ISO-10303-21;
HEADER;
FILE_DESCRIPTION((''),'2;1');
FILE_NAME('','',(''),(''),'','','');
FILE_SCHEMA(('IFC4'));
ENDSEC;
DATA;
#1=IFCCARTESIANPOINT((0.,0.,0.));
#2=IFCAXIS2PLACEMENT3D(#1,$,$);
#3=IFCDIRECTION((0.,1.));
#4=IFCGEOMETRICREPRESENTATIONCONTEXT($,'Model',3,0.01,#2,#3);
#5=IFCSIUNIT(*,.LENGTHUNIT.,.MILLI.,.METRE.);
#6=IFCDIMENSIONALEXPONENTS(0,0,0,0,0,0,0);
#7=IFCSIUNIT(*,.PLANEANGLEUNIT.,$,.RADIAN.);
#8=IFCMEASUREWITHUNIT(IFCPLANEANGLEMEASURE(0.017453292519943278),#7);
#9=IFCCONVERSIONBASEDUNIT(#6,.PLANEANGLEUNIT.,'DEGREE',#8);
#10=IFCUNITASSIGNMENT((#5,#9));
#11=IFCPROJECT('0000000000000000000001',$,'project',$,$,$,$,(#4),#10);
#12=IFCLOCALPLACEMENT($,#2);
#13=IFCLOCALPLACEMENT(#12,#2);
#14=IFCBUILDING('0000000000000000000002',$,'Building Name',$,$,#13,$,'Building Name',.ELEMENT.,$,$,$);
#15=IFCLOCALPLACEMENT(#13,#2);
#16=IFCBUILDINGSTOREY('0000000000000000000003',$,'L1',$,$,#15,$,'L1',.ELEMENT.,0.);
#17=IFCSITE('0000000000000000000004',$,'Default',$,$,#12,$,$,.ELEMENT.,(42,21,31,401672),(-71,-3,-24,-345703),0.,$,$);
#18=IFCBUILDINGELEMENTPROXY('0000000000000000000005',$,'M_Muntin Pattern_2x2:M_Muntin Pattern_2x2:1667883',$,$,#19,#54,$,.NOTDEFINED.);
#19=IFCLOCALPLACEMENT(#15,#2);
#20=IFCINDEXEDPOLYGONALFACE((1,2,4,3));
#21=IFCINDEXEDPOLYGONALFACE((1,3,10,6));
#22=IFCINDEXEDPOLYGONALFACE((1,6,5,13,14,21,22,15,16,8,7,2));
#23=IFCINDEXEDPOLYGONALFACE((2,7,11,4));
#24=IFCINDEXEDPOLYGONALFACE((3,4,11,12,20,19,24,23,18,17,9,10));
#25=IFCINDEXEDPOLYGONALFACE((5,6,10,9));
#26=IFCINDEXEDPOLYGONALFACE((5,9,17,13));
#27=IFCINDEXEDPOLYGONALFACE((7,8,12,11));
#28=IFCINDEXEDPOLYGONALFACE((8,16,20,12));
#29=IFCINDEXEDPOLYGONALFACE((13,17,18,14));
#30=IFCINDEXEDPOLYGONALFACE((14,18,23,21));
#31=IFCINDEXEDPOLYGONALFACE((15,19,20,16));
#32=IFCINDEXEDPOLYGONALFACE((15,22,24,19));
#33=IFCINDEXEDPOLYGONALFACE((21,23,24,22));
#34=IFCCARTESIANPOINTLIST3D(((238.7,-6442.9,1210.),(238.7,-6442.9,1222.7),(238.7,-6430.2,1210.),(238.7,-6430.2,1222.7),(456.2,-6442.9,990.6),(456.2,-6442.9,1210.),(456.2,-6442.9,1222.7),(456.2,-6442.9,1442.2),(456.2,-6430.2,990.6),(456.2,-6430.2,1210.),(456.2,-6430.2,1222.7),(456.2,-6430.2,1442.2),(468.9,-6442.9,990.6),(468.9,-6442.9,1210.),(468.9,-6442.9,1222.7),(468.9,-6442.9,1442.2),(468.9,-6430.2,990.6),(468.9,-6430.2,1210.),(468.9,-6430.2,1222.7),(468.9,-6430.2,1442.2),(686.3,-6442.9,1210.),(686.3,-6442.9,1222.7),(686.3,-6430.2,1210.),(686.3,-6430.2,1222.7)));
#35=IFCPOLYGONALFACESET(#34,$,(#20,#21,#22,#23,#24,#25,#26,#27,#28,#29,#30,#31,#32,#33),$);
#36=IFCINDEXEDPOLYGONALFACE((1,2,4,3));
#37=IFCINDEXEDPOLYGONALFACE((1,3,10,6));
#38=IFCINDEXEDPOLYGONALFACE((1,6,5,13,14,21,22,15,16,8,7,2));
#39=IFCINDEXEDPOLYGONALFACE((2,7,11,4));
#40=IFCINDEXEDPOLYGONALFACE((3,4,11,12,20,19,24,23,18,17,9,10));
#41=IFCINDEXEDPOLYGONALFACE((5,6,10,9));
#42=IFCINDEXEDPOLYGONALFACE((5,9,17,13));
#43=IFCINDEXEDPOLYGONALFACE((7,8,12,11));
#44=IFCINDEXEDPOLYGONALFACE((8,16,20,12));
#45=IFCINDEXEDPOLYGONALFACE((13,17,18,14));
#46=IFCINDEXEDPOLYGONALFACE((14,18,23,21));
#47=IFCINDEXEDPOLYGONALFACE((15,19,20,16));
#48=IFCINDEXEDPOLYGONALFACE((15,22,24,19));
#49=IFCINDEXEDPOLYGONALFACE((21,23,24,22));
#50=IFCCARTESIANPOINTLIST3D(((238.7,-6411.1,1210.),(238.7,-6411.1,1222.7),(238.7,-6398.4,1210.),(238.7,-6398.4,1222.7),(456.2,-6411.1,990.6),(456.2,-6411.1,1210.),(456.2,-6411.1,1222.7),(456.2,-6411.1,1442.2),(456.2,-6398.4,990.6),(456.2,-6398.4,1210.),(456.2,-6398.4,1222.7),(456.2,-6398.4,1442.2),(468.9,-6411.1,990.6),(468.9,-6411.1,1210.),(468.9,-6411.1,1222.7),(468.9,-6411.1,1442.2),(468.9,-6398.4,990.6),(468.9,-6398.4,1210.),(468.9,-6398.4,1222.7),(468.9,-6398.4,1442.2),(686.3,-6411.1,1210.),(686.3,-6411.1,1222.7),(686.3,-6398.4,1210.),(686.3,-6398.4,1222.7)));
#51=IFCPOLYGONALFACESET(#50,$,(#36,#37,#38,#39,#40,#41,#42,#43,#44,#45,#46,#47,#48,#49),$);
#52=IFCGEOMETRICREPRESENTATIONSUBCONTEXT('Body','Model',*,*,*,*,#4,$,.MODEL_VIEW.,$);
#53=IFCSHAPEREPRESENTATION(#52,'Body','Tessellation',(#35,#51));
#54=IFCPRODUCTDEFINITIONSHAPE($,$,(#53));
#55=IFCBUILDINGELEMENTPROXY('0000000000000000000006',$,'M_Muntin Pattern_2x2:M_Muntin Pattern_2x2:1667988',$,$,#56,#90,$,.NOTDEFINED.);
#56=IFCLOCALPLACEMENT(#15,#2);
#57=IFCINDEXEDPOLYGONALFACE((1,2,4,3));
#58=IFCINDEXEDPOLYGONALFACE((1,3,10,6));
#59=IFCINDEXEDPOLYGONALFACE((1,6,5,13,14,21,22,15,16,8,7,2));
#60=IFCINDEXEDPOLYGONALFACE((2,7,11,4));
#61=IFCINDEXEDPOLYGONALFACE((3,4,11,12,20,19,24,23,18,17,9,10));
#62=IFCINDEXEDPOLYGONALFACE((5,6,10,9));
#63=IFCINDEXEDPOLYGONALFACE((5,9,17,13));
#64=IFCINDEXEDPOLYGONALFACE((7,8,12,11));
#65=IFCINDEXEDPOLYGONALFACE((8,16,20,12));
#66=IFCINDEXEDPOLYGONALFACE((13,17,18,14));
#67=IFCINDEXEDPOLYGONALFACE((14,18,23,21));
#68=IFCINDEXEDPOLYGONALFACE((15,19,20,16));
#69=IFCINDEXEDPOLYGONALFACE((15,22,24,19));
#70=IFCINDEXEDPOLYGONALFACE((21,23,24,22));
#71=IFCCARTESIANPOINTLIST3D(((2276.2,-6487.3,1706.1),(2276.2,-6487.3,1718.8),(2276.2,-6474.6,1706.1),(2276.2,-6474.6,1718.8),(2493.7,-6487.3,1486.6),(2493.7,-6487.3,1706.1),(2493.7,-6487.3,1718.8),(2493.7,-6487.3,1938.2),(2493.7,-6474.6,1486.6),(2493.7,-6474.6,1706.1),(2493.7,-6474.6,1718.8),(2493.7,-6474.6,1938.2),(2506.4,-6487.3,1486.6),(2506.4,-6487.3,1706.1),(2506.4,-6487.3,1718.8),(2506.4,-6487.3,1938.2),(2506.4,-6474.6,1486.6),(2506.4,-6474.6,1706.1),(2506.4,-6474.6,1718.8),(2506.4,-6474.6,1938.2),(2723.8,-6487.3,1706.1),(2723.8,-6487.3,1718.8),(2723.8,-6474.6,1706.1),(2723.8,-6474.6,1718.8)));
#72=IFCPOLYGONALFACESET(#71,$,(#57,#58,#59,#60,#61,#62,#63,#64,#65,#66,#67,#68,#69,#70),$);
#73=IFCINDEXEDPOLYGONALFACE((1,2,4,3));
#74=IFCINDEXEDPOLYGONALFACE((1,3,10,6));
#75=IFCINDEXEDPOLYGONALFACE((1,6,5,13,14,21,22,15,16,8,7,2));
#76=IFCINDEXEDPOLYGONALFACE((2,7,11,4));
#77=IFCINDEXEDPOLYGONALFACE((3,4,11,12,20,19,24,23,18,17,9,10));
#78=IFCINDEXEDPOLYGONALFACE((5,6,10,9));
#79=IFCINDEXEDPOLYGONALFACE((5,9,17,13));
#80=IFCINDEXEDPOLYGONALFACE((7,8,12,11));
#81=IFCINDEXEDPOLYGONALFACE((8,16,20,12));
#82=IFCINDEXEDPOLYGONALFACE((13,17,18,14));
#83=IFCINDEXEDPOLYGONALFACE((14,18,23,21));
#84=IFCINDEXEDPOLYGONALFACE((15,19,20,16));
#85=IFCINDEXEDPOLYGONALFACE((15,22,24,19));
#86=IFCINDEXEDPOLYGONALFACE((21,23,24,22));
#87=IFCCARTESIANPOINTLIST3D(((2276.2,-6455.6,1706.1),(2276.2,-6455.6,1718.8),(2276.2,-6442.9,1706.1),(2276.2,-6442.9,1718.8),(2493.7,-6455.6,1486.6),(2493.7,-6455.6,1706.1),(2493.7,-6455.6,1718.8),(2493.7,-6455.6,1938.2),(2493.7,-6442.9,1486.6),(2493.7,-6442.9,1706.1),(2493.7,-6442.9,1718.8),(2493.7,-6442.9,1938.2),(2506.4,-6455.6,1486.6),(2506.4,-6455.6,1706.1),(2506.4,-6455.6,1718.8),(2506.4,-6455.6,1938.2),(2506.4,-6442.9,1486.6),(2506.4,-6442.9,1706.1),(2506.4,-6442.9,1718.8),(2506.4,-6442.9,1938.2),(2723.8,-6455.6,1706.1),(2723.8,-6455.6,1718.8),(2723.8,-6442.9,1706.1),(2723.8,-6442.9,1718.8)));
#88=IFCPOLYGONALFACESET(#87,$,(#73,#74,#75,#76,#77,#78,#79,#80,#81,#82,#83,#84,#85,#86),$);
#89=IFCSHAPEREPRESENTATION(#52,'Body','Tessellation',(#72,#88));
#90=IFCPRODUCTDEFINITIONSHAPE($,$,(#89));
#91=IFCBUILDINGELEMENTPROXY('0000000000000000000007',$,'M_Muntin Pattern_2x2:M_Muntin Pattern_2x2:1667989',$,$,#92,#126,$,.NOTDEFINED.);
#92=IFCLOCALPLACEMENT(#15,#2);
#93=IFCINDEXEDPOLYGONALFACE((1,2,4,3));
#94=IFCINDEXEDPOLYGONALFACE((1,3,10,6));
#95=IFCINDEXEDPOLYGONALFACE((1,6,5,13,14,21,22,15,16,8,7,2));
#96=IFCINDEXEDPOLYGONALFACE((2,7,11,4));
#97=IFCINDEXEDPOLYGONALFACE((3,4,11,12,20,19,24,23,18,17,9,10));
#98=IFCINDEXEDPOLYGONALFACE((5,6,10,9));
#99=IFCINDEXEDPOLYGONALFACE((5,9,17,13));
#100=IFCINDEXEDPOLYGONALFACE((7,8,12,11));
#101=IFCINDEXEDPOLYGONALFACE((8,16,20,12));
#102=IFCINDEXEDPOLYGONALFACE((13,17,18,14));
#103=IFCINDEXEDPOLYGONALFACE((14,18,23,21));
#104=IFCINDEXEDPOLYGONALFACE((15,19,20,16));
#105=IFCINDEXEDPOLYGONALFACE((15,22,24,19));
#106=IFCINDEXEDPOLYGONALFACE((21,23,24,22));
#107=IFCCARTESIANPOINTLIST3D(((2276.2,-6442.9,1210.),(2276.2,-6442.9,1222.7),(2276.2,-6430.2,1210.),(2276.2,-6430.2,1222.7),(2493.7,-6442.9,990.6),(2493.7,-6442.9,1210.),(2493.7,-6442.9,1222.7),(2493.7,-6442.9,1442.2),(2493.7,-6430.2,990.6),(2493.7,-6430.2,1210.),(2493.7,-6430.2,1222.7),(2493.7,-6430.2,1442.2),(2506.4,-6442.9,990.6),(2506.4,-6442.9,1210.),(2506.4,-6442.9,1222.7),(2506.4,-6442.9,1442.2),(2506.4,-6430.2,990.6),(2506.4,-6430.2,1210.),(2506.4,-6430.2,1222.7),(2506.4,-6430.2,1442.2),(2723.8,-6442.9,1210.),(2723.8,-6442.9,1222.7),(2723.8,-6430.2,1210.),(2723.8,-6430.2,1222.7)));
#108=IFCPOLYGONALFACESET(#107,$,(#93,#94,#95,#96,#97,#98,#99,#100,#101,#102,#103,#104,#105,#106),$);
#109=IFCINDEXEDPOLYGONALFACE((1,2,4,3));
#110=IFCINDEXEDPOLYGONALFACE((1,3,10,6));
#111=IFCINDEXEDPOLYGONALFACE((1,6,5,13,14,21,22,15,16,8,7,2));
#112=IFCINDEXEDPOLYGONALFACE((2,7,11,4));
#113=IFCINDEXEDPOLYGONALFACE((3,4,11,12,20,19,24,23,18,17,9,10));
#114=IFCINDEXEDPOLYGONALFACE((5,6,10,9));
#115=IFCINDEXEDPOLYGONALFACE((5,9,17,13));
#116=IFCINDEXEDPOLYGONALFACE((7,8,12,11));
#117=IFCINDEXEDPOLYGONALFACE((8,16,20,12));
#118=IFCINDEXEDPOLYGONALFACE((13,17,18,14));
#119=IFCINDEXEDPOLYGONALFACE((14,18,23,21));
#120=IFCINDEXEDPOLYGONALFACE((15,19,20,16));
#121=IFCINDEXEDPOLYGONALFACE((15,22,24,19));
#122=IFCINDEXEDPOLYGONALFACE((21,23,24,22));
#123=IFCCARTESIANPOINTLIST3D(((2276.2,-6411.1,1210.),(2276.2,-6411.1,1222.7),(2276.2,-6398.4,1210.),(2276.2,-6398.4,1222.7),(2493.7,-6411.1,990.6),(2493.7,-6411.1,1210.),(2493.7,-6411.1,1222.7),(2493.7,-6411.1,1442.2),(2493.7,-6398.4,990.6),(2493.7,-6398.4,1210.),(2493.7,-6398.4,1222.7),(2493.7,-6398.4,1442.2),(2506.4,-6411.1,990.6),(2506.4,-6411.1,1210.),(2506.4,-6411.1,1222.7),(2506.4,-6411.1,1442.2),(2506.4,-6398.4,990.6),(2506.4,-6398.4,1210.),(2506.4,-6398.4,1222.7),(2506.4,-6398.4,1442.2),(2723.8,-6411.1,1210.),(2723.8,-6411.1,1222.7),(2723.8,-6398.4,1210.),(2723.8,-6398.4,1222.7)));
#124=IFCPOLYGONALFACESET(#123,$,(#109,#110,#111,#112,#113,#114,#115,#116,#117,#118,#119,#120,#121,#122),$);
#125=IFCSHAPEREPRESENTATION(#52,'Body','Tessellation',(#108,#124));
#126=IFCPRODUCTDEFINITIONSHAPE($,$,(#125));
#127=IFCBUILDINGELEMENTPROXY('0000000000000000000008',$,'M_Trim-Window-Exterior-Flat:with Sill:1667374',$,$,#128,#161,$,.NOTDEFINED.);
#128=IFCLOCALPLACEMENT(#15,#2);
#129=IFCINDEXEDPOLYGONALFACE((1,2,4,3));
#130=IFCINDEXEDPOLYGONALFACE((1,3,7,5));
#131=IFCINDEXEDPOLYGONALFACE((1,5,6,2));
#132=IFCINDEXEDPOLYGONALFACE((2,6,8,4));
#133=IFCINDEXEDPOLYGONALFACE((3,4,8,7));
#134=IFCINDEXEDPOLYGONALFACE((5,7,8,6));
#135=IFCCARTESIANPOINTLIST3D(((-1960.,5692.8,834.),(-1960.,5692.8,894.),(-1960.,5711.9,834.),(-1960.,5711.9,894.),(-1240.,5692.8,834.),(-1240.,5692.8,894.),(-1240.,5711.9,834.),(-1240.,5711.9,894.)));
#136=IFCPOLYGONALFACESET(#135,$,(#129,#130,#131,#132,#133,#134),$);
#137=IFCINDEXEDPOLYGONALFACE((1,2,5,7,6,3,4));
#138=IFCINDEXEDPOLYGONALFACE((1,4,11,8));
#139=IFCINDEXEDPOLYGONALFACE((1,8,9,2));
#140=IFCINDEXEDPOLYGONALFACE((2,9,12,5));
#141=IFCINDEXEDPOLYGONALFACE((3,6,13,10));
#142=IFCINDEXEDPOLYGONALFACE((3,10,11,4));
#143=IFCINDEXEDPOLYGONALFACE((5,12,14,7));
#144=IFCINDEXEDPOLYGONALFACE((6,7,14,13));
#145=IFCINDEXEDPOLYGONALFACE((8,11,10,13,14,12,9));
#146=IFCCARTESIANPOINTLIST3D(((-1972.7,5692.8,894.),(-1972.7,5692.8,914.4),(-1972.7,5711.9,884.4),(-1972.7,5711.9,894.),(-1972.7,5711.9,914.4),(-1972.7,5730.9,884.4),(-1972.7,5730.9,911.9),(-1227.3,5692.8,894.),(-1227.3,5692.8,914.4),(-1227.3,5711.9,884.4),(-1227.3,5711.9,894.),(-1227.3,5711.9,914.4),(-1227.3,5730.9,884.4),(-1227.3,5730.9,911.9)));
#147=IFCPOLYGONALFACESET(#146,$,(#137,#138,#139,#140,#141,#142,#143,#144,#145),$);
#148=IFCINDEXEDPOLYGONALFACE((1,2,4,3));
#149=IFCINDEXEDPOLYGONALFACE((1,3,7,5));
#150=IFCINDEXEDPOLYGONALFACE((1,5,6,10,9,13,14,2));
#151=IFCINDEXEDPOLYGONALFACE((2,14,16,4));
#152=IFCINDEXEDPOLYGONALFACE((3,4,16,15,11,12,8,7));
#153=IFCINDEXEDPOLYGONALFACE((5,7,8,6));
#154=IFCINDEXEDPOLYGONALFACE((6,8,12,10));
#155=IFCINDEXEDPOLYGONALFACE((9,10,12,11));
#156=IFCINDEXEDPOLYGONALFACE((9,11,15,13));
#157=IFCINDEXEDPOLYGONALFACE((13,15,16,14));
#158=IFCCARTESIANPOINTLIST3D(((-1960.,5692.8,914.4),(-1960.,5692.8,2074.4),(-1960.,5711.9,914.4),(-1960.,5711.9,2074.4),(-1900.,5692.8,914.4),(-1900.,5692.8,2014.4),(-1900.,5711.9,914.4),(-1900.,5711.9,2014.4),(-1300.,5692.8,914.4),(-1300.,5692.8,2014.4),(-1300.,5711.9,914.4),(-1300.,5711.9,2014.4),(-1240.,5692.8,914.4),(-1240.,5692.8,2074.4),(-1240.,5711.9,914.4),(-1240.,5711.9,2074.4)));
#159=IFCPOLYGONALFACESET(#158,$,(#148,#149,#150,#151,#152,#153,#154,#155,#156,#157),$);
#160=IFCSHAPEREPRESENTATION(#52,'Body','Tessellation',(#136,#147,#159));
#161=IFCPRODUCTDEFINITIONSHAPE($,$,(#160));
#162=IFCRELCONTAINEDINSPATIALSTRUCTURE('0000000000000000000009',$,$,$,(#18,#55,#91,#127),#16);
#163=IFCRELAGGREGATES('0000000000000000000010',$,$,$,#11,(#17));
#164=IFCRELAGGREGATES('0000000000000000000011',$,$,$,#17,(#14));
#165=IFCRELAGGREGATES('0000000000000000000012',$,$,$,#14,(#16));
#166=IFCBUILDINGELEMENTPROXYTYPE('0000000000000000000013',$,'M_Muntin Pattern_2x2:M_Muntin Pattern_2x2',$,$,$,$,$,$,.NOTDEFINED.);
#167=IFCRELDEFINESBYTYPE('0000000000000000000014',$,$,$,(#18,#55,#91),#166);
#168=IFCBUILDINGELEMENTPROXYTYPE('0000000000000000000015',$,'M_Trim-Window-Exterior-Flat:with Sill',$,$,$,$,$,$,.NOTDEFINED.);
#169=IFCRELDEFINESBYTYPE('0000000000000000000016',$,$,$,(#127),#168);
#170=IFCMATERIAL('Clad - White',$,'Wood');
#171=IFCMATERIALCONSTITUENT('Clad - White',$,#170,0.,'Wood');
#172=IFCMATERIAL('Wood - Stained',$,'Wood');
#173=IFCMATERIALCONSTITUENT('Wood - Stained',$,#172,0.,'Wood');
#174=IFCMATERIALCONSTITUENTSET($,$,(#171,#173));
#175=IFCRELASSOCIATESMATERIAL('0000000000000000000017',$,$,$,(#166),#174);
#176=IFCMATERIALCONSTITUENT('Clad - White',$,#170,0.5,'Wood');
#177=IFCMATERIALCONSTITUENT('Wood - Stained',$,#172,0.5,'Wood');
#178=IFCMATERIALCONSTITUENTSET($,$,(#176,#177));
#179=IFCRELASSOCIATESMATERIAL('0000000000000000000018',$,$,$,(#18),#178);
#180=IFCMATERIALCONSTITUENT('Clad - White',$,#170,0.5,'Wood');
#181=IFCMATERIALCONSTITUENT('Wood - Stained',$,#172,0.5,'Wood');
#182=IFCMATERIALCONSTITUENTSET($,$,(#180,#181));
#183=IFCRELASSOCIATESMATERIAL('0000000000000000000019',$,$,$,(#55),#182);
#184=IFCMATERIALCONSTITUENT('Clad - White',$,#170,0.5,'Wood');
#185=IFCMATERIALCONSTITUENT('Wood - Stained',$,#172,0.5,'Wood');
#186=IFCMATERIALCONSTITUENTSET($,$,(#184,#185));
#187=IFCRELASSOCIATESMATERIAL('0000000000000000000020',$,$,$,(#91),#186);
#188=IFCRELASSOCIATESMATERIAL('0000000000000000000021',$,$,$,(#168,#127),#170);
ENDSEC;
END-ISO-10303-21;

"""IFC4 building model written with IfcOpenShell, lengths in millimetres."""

from ifc_helpers import new_model, entity, si_unit, converted_unit, direction, frame, origin, place, context, subcontext, project, spatial, indexed_curve, outline, extrude, source, transform, mapped, material, constituent, constituent_set, type_object, type_shapes, element, save


model = new_model("IFC4")

# Units and contexts
model_context = context("Model", 3, precision=0.01, world=origin(), true_north=direction((0.0, 1.0)))
body_context = subcontext(model_context, "Body", "Model", "MODEL_VIEW")
ifc_project = project(units=[si_unit("LENGTHUNIT", "METRE", prefix="MILLI"), converted_unit("PLANEANGLEUNIT", "DEGREE", entity("IfcPlaneAngleMeasure", 0.017453292519943278), si_unit("PLANEANGLEUNIT", "RADIAN"), dimensions=[0, 0, 0, 0, 0, 0, 0])], contexts=[model_context])

# Site, building, storey
site_placement = place(None, origin())
site = spatial("IfcSite", under=ifc_project, at=site_placement, Name="Default", CompositionType="ELEMENT", RefLatitude=(42, 21, 31, 401672), RefLongitude=(-71, -3, -24, -345703), RefElevation=0.0)
building_placement = place(site_placement, origin())
building = spatial("IfcBuilding", under=site, at=building_placement, Name="Building Name", LongName="Building Name", CompositionType="ELEMENT")
storey_placement = place(building_placement, origin())
storey = spatial("IfcBuildingStorey", under=building, at=storey_placement, Name="L1", LongName="L1", CompositionType="ELEMENT", Elevation=0.0)

# Building element proxies
ifc_material_1 = material(Name="Clad - White", Category="Wood")
ifc_material_2 = material(Name="Wood - Stained", Category="Wood")
ifc_constituent_1 = constituent(ifc_material_1, Name="Clad - White", Category="Wood", fraction=0.0)
ifc_constituent_2 = constituent(ifc_material_2, Name="Wood - Stained", Category="Wood", fraction=0.0)
ifc_constituent_set_1 = constituent_set(constituents=[ifc_constituent_1, ifc_constituent_2])
building_element_proxy_type_1 = type_object("IfcBuildingElementProxyType", Name="M_Muntin Pattern_2x2:M_Muntin Pattern_2x2", PredefinedType="NOTDEFINED", material=ifc_constituent_set_1)
shared_shape_1 = source(origin(), body_context, "Body", "SweptSolid", [
    extrude(outline(indexed_curve([(6.4, -6.4), (225.8, -6.4), (225.8, 6.3), (6.4, 6.3), (6.4, 223.8), (-6.3, 223.8), (-6.3, 6.3), (-225.8, 6.3), (-225.8, -6.4), (-6.3, -6.4), (-6.3, -223.8), (6.4, -223.8), (6.4, -6.4)], self_intersect=False)), frame((0.0, 9.5, 225.8), z_axis=(0.0, 1.0, 0.0), x_axis=(0.0, 0.0, 1.0)), (0.0, 0.0, 1.0), 12.7),
    extrude(outline(indexed_curve([(6.4, -6.4), (225.8, -6.4), (225.8, 6.3), (6.4, 6.3), (6.4, 223.8), (-6.3, 223.8), (-6.3, 6.3), (-225.8, 6.3), (-225.8, -6.4), (-6.3, -6.4), (-6.3, -223.8), (6.4, -223.8), (6.4, -6.4)], self_intersect=False)), frame((0.0, -22.2, 225.8), z_axis=(0.0, 1.0, 0.0), x_axis=(0.0, 0.0, 1.0)), (0.0, 0.0, 1.0), 12.7),
])
type_shapes(building_element_proxy_type_1, [shared_shape_1])
ifc_constituent_3 = constituent(ifc_material_1, Name="Clad - White", Category="Wood", fraction=0.5)
ifc_constituent_4 = constituent(ifc_material_2, Name="Wood - Stained", Category="Wood", fraction=0.5)
ifc_constituent_set_2 = constituent_set(constituents=[ifc_constituent_3, ifc_constituent_4])
proxy_1_placement = place(storey_placement, frame((462.5, -6420.6, 990.6), z_axis=(0.0, 0.0, 1.0), x_axis=(-1.0, 0.0, 0.0)))
element("IfcBuildingElementProxy", 1, at=proxy_1_placement, inside=storey, type_object=building_element_proxy_type_1, material=ifc_constituent_set_2, Name="M_Muntin Pattern_2x2:M_Muntin Pattern_2x2:1667883", PredefinedType="NOTDEFINED", context=body_context, shape_type="MappedRepresentation", body=[
    mapped(shared_shape_1, transform((0.0, 0.0, 0.0), scale=1.0)),
])
ifc_constituent_5 = constituent(ifc_material_1, Name="Clad - White", Category="Wood", fraction=0.5)
ifc_constituent_6 = constituent(ifc_material_2, Name="Wood - Stained", Category="Wood", fraction=0.5)
ifc_constituent_set_3 = constituent_set(constituents=[ifc_constituent_5, ifc_constituent_6])
proxy_2_placement = place(storey_placement, frame((2500.0, -6465.1, 1486.6), z_axis=(0.0, 0.0, 1.0), x_axis=(-1.0, 0.0, 0.0)))
element("IfcBuildingElementProxy", 2, at=proxy_2_placement, inside=storey, type_object=building_element_proxy_type_1, material=ifc_constituent_set_3, Name="M_Muntin Pattern_2x2:M_Muntin Pattern_2x2:1667988", PredefinedType="NOTDEFINED", context=body_context, shape_type="MappedRepresentation", body=[
    mapped(shared_shape_1, transform((0.0, 0.0, 0.0), scale=1.0)),
])
ifc_constituent_7 = constituent(ifc_material_1, Name="Clad - White", Category="Wood", fraction=0.5)
ifc_constituent_8 = constituent(ifc_material_2, Name="Wood - Stained", Category="Wood", fraction=0.5)
ifc_constituent_set_4 = constituent_set(constituents=[ifc_constituent_7, ifc_constituent_8])
proxy_3_placement = place(storey_placement, frame((2500.0, -6420.6, 990.6), z_axis=(0.0, 0.0, 1.0), x_axis=(-1.0, 0.0, 0.0)))
element("IfcBuildingElementProxy", 3, at=proxy_3_placement, inside=storey, type_object=building_element_proxy_type_1, material=ifc_constituent_set_4, Name="M_Muntin Pattern_2x2:M_Muntin Pattern_2x2:1667989", PredefinedType="NOTDEFINED", context=body_context, shape_type="MappedRepresentation", body=[
    mapped(shared_shape_1, transform((0.0, 0.0, 0.0), scale=1.0)),
])
building_element_proxy_type_2 = type_object("IfcBuildingElementProxyType", Name="M_Trim-Window-Exterior-Flat:with Sill", PredefinedType="NOTDEFINED", material=ifc_material_1)
shared_shape_2 = source(origin(), body_context, "Body", "SweptSolid", [
    extrude(outline(indexed_curve([(-360.0, -30.0), (360.0, -30.0), (360.0, 30.0), (-360.0, 30.0), (-360.0, -30.0)], self_intersect=False)), frame((0.0, -1150.4, 0.0), z_axis=(0.0, 0.0, 1.0), x_axis=(-1.0, 0.0, 0.0)), (0.0, 0.0, 1.0), 19.0),
    extrude(outline(indexed_curve([(-19.0, -15.2), (0.0, -15.2), (0.0, -5.7), (19.0, -5.7), (19.0, 14.8), (0.0, 14.8), (-19.0, 12.3), (-19.0, -15.2)], self_intersect=False)), frame((-372.7, -1114.8, 19.0), z_axis=(1.0, 0.0, 0.0), x_axis=(0.0, 0.0, -1.0)), (0.0, 0.0, 1.0), 745.4),
    extrude(outline(indexed_curve([(-595.0, -360.0), (565.0, -360.0), (565.0, -300.0), (-535.0, -300.0), (-535.0, 300.0), (565.0, 300.0), (565.0, 360.0), (-595.0, 360.0), (-595.0, -360.0)], self_intersect=False)), frame((0.0, -535.0, 0.0), z_axis=(0.0, 0.0, 1.0), x_axis=(0.0, -1.0, 0.0)), (0.0, 0.0, 1.0), 19.0),
])
type_shapes(building_element_proxy_type_2, [shared_shape_2])
for number, where, z_axis, x_axis, name in (
    (4, (-1600.0, 5692.8, 2014.4), (0.0, 1.0, 0.0), (-1.0, 0.0, 0.0), "M_Trim-Window-Exterior-Flat:with Sill:1667374"),
):
    element("IfcBuildingElementProxy", number, at=place(storey_placement, frame(where, z_axis=z_axis, x_axis=x_axis)), inside=storey, type_object=building_element_proxy_type_2, material=ifc_material_1, Name=name, PredefinedType="NOTDEFINED", context=body_context, shape_type="MappedRepresentation", body=[
        mapped(shared_shape_2, transform((0.0, 0.0, 0.0), scale=1.0)),
    ])

save(model, "model.ifc")
